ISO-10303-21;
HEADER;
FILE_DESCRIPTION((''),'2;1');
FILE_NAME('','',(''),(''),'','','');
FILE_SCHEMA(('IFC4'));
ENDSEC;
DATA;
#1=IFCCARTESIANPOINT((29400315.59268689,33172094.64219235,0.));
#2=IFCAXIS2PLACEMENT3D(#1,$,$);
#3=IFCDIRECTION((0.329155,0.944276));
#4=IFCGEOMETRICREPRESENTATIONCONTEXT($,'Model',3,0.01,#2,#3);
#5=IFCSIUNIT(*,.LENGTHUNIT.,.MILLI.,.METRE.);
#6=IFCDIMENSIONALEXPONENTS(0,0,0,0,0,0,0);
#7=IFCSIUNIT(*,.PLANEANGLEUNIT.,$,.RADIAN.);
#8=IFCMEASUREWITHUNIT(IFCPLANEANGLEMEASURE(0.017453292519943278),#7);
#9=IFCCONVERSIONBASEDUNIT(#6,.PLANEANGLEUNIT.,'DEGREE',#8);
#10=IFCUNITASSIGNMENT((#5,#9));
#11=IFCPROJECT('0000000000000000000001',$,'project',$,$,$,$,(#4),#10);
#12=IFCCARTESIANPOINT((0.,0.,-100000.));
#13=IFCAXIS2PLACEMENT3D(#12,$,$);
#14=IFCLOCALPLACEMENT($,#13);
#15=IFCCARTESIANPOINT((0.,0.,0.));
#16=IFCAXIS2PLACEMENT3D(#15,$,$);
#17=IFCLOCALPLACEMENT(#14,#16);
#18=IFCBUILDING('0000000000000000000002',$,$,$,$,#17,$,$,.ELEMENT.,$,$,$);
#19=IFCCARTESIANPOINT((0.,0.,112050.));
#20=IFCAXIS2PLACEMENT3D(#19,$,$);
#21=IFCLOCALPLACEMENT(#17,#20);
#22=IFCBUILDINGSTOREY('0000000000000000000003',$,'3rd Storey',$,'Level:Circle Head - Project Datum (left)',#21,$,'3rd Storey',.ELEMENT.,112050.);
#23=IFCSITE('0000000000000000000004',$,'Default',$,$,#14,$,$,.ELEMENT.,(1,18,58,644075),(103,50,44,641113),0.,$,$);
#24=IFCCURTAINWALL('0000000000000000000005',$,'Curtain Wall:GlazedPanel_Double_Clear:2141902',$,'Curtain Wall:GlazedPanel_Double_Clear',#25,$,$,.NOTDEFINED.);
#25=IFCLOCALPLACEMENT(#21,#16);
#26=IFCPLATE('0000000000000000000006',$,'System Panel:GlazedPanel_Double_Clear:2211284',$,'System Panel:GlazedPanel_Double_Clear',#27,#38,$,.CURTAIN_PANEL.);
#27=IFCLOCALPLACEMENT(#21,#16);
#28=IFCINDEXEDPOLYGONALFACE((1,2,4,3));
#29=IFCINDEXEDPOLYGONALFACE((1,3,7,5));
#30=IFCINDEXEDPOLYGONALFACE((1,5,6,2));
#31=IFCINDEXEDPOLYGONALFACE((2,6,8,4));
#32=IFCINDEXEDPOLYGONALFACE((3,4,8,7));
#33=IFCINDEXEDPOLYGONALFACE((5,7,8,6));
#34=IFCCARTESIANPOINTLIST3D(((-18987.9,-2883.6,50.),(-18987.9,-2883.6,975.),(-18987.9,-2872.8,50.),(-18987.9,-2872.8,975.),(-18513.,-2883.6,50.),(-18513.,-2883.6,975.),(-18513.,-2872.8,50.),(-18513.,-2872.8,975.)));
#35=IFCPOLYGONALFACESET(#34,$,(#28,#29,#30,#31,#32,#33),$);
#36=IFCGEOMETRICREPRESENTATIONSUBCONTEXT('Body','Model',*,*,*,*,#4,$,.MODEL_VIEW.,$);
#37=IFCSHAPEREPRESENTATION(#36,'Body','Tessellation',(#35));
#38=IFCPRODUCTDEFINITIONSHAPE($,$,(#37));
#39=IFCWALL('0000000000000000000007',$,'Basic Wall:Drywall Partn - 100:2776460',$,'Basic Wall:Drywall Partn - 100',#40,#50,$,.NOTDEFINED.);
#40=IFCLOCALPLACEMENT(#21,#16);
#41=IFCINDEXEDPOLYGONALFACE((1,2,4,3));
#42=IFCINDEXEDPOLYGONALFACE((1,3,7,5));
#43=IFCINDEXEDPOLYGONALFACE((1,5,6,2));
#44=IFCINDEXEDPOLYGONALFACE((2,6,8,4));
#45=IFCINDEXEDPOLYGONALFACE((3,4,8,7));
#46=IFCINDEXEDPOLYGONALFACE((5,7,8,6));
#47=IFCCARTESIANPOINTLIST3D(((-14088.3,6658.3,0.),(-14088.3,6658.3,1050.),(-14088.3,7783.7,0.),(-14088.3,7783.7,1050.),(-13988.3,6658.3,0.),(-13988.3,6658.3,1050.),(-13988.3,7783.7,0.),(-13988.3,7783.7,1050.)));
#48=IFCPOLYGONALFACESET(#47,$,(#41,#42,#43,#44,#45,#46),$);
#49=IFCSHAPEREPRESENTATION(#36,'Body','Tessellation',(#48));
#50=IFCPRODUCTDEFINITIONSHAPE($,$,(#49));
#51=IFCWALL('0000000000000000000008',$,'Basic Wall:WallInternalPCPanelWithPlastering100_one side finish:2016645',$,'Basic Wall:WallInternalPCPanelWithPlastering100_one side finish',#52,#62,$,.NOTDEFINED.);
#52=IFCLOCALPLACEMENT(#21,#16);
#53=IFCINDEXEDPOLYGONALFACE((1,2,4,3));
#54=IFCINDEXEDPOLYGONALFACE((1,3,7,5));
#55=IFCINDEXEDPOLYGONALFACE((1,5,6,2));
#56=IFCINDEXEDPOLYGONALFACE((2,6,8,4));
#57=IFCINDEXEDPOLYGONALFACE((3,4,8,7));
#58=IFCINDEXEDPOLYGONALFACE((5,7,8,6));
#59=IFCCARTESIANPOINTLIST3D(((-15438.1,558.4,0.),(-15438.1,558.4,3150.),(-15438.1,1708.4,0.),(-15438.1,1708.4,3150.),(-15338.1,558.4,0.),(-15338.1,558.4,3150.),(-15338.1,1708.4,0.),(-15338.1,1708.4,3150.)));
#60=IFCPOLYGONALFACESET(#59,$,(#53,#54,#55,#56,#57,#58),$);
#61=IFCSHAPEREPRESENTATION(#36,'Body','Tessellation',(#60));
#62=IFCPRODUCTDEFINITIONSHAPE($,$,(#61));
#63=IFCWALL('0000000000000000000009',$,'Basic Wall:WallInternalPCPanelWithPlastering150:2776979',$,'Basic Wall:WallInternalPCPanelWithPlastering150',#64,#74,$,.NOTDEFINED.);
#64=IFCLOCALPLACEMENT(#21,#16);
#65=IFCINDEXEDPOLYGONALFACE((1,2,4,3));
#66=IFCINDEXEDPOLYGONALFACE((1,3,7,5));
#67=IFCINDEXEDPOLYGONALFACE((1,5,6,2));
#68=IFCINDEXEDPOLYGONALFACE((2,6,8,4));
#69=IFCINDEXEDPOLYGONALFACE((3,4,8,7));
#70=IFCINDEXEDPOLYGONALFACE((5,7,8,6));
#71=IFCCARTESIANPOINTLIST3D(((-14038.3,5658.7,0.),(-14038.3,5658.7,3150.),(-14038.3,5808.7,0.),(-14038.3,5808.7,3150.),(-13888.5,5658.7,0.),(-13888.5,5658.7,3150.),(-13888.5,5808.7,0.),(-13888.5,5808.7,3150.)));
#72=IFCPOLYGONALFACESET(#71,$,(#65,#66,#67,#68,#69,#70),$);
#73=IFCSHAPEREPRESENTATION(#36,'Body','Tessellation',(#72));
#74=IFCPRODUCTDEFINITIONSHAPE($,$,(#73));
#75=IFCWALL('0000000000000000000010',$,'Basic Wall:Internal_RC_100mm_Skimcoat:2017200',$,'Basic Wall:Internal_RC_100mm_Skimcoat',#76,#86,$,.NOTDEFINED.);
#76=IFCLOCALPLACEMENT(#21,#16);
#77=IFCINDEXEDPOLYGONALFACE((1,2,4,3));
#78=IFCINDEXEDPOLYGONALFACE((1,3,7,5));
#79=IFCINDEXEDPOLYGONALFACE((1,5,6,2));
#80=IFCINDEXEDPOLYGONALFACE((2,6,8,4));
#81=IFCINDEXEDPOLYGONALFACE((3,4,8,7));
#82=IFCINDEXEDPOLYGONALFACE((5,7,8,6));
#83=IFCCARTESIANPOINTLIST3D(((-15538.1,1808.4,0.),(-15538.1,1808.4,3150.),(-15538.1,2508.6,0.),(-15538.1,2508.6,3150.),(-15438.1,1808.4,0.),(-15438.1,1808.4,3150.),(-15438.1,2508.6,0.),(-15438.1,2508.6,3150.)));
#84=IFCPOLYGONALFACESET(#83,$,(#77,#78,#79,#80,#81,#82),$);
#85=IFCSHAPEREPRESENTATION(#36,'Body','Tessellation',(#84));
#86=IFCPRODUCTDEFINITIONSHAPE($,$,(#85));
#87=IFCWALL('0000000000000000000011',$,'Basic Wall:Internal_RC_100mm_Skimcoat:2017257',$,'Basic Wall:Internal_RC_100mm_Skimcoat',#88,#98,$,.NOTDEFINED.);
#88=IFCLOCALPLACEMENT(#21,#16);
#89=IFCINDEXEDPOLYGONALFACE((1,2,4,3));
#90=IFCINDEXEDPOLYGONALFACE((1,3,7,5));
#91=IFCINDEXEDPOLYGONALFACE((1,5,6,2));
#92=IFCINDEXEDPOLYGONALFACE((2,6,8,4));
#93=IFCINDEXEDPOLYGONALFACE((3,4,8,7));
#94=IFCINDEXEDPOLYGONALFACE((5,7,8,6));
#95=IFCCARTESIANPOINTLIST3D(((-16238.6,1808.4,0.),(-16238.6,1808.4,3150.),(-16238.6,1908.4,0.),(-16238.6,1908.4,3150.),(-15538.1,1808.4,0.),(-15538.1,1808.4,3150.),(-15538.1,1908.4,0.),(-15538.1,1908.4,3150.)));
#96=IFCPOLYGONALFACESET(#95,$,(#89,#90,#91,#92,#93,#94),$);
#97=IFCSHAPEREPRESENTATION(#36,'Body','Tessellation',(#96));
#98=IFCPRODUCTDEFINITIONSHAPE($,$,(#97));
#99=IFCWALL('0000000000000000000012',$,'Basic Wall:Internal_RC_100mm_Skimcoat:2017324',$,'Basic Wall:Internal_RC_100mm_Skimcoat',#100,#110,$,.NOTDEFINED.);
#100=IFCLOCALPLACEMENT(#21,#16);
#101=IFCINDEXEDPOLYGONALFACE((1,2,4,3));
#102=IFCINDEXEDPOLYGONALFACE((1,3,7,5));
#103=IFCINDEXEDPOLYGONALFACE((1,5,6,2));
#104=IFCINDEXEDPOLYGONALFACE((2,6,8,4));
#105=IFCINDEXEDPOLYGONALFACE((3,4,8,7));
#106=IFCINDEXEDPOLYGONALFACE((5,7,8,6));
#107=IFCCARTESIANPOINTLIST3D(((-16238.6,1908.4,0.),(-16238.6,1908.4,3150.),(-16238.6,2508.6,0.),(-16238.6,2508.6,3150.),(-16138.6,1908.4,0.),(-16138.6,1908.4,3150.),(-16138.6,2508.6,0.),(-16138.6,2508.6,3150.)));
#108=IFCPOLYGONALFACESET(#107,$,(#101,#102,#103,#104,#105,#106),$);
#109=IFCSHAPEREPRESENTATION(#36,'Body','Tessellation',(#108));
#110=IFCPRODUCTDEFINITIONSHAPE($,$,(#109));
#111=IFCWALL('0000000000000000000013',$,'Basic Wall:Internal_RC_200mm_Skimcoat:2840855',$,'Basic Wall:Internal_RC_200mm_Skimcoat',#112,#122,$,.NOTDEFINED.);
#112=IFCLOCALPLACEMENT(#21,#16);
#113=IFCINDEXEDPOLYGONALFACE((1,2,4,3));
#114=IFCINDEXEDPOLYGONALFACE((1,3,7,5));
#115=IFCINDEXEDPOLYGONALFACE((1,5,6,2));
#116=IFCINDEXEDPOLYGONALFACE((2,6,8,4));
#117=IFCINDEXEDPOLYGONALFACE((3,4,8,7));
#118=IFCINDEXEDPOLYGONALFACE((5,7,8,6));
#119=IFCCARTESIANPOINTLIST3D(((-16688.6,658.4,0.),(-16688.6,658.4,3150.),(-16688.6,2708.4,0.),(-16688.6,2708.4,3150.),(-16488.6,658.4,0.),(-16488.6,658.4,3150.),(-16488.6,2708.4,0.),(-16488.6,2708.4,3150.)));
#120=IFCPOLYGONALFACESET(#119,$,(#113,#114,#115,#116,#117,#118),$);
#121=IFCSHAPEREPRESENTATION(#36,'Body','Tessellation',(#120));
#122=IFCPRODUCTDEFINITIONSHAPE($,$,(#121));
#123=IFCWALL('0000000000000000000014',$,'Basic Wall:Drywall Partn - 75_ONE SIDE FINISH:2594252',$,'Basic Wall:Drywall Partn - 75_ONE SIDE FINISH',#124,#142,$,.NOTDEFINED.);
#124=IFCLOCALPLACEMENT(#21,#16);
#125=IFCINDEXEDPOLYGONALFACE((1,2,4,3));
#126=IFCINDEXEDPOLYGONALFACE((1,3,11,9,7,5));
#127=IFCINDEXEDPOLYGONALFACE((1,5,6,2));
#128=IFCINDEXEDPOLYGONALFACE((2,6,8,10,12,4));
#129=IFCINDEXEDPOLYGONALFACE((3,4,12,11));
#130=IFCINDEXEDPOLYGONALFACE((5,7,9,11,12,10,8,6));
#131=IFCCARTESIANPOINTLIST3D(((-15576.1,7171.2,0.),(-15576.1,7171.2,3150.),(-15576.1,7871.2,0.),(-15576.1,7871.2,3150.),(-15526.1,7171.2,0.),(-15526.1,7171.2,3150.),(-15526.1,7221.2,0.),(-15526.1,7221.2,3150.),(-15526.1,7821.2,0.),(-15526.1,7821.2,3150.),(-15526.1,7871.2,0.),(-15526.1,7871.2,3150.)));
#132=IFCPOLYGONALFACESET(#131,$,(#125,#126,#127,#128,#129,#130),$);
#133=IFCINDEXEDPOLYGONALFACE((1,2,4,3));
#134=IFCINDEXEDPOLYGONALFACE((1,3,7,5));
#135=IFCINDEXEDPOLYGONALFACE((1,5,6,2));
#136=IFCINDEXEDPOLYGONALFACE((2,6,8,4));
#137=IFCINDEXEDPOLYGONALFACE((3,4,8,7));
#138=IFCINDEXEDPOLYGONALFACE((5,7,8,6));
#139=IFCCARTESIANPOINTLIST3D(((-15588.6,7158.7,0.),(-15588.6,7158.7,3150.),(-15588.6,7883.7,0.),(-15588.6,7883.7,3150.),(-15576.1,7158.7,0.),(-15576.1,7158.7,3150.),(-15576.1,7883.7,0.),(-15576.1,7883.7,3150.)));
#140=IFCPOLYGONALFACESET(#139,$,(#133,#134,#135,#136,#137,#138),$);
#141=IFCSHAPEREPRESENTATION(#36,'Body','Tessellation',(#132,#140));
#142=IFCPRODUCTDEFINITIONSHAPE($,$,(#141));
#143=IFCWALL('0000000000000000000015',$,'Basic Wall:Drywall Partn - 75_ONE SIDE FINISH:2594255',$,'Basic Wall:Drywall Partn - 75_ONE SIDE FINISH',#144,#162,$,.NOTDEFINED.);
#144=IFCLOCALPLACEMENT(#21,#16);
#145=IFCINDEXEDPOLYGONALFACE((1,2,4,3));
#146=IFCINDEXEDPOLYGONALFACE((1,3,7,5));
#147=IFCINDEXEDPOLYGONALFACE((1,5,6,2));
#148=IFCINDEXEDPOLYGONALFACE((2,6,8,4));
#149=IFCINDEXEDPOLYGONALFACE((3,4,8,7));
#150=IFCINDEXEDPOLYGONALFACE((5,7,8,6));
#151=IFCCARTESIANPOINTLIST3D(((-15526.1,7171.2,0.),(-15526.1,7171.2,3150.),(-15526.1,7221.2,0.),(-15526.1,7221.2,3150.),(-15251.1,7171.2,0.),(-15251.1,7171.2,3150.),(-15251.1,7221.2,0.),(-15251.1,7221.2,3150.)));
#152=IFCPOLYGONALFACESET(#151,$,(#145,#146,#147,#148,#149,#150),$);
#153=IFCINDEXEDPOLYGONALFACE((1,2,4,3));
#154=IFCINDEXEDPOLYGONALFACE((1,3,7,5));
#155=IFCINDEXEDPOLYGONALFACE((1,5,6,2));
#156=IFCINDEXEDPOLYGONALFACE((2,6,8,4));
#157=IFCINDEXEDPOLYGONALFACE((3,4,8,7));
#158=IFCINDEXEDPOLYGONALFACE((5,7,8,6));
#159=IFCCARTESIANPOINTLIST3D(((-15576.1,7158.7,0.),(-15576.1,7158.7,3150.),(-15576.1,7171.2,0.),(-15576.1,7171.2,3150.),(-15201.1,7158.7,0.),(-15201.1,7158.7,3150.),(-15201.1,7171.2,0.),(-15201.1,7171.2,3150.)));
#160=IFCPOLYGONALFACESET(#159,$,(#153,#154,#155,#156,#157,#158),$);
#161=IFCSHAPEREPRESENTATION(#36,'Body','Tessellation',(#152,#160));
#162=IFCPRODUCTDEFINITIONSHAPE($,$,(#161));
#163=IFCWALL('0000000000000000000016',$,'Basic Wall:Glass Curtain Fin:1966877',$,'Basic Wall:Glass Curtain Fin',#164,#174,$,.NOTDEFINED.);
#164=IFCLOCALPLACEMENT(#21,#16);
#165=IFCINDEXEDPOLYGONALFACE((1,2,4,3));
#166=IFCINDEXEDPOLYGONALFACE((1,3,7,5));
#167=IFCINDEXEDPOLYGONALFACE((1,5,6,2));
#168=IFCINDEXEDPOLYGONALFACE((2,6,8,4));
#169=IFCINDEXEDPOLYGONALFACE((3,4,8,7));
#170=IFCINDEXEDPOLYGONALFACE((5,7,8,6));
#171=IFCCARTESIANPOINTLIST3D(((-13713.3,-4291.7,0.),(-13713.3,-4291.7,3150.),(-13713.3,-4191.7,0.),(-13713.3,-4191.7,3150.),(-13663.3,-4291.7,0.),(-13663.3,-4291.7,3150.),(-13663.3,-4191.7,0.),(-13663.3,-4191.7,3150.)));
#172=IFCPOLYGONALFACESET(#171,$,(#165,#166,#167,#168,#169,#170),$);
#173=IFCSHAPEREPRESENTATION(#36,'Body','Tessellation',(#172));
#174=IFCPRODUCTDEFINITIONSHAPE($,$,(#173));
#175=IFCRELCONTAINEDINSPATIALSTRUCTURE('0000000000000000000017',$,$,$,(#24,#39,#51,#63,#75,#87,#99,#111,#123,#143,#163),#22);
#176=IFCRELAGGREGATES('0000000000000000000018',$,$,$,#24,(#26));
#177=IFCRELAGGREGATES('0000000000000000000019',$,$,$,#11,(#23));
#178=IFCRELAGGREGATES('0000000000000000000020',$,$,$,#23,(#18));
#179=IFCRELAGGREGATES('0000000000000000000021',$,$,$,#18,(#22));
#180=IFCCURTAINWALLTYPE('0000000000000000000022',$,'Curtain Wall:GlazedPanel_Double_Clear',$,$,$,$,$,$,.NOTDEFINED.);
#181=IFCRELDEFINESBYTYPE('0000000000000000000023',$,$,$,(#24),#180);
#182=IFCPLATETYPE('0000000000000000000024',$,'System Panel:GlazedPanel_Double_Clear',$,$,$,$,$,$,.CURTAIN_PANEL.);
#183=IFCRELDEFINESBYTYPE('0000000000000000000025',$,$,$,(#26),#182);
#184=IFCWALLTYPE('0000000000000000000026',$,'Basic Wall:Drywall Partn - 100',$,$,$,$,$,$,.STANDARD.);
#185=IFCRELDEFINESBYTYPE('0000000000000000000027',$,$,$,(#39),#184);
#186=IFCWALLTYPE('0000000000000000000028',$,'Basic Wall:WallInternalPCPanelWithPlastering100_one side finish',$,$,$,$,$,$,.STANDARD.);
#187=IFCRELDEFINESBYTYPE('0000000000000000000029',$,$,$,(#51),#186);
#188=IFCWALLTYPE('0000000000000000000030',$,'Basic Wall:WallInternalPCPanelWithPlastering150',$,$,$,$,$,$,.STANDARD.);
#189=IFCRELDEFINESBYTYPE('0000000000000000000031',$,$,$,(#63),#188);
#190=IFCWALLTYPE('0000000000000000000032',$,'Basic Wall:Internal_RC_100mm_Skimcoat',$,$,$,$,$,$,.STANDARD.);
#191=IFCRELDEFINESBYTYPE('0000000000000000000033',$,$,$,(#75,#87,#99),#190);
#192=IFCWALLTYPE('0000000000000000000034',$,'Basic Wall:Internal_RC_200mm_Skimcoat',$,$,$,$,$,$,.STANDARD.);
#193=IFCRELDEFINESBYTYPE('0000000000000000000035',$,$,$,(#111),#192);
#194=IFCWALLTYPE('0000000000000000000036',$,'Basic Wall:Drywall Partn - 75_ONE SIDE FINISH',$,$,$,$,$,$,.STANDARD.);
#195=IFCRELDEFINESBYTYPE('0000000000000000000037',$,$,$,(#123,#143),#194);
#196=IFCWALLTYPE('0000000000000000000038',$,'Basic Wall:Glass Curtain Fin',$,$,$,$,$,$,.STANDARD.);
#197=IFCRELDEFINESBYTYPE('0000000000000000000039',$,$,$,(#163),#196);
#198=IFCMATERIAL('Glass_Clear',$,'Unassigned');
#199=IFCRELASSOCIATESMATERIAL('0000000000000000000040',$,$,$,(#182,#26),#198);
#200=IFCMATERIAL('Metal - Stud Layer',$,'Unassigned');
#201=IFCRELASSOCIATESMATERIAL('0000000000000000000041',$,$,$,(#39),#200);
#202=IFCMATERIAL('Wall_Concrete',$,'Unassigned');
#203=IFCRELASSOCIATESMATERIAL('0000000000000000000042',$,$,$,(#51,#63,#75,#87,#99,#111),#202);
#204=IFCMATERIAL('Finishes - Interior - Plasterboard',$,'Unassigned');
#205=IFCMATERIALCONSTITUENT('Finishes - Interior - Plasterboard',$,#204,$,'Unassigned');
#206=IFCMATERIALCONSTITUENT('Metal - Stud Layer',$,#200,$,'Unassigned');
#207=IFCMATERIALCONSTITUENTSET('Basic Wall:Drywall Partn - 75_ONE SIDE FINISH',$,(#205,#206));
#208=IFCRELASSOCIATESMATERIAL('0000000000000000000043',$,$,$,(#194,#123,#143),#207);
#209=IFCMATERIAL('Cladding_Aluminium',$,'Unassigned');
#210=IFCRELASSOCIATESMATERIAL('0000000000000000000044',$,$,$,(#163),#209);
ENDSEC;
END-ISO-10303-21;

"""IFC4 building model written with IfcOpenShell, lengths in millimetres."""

from ifc_helpers import new_model, entity, si_unit, converted_unit, direction, frame, origin, place, context, subcontext, project, spatial, indexed_curve, outline, extrude, source, transform, mapped, material, constituent, constituent_set, type_object, type_shapes, element, aggregate, save


model = new_model("IFC4")

# Units and contexts
model_context = context("Model", 3, precision=0.01, world=frame((29400315.59268689, 33172094.64219235, 0.0)), true_north=direction((0.329155, 0.944276)))
body_context = subcontext(model_context, "Body", "Model", "MODEL_VIEW")
ifc_project = project(units=[si_unit("LENGTHUNIT", "METRE", prefix="MILLI"), converted_unit("PLANEANGLEUNIT", "DEGREE", entity("IfcPlaneAngleMeasure", 0.017453292519943278), si_unit("PLANEANGLEUNIT", "RADIAN"), dimensions=[0, 0, 0, 0, 0, 0, 0])], contexts=[model_context])

# Site, building, storey
site_placement = place(None, frame((0.0, 0.0, -100000.0)))
site = spatial("IfcSite", under=ifc_project, at=site_placement, Name="Default", CompositionType="ELEMENT", RefLatitude=(1, 18, 58, 644075), RefLongitude=(103, 50, 44, 641113), RefElevation=0.0)
building_placement = place(site_placement, origin())
building = spatial("IfcBuilding", under=site, at=building_placement, CompositionType="ELEMENT")
storey_placement = place(building_placement, frame((0.0, 0.0, 112050.0)))
storey = spatial("IfcBuildingStorey", under=building, at=storey_placement, Name="3rd Storey", ObjectType="Level:Circle Head - Project Datum (left)", LongName="3rd Storey", CompositionType="ELEMENT", Elevation=112050.0)

# Shared definitions
curtain_wall_type = type_object("IfcCurtainWallType", Name="Curtain Wall:GlazedPanel_Double_Clear", PredefinedType="NOTDEFINED")

# Curtain wall
curtain_wall_1_placement = place(storey_placement, frame((0.0, 0.0, -112050.0)))
curtain_wall_1 = element("IfcCurtainWall", 1, at=curtain_wall_1_placement, inside=storey, type_object=curtain_wall_type, Name="Curtain Wall:GlazedPanel_Double_Clear:2141902", ObjectType="Curtain Wall:GlazedPanel_Double_Clear", PredefinedType="NOTDEFINED")

# Plate
ifc_material_1 = material(Name="Glass_Clear", Category="Unassigned")
plate_type_1 = type_object("IfcPlateType", Name="System Panel:GlazedPanel_Double_Clear", PredefinedType="CURTAIN_PANEL", material=ifc_material_1)
shared_shape_1 = source(origin(), body_context, "Body", "SweptSolid", [
    extrude(outline(indexed_curve([(-5.4, -237.5), (5.4, -237.5), (5.4, 237.5), (-5.4, 237.5), (-5.4, -237.5)], self_intersect=False)), frame((0.0, -111.0, 0.0), z_axis=(0.0, 0.0, 1.0), x_axis=(0.0, 1.0, 0.0)), (0.0, 0.0, 1.0), 925.0),
])
type_shapes(plate_type_1, [shared_shape_1])
plate_1_placement = place(curtain_wall_1_placement, frame((-18750.4, -2767.2, 112100.0)))
plate_1 = element("IfcPlate", 2, at=plate_1_placement, type_object=plate_type_1, material=ifc_material_1, Name="System Panel:GlazedPanel_Double_Clear:2211284", ObjectType="System Panel:GlazedPanel_Double_Clear", PredefinedType="CURTAIN_PANEL", context=body_context, shape_type="MappedRepresentation", body=[
    mapped(shared_shape_1, transform((0.0, 0.0, 0.0), scale=1.0)),
])
aggregate(curtain_wall_1, [plate_1])

# Walls
ifc_material_2 = material(Name="Metal - Stud Layer", Category="Unassigned")
wall_type_1 = type_object("IfcWallType", Name="Basic Wall:Drywall Partn - 100", PredefinedType="STANDARD")
wall_1_placement = place(storey_placement, frame((-14038.3, 7783.7, 0.0), z_axis=(0.0, 0.0, 1.0), x_axis=(0.0, -1.0, 0.0)))
element("IfcWall", 3, at=wall_1_placement, inside=storey, type_object=wall_type_1, material=ifc_material_2, Name="Basic Wall:Drywall Partn - 100:2776460", ObjectType="Basic Wall:Drywall Partn - 100", PredefinedType="NOTDEFINED", context=body_context, shape_type="SweptSolid", body=[
    extrude(outline(indexed_curve([(1125.4, 50.0), (0.0, 50.0), (0.0, -50.0), (1125.4, -50.0), (1125.4, 50.0)], self_intersect=False)), origin(), (0.0, 0.0, 1.0), 1050.0),
])
ifc_material_3 = material(Name="Wall_Concrete", Category="Unassigned")
wall_type_2 = type_object("IfcWallType", Name="Basic Wall:WallInternalPCPanelWithPlastering100_one side finish", PredefinedType="STANDARD")
wall_2_placement = place(storey_placement, frame((-15388.1, 558.4, 0.0), z_axis=(0.0, 0.0, 1.0), x_axis=(0.0, 1.0, 0.0)))
element("IfcWall", 4, at=wall_2_placement, inside=storey, type_object=wall_type_2, material=ifc_material_3, Name="Basic Wall:WallInternalPCPanelWithPlastering100_one side finish:2016645", ObjectType="Basic Wall:WallInternalPCPanelWithPlastering100_one side finish", PredefinedType="NOTDEFINED", context=body_context, shape_type="SweptSolid", body=[
    extrude(outline(indexed_curve([(1150.0, 50.0), (0.0, 50.0), (0.0, -50.0), (1150.0, -50.0), (1150.0, 50.0)], self_intersect=False)), origin(), (0.0, 0.0, 1.0), 3150.0),
])
wall_type_3 = type_object("IfcWallType", Name="Basic Wall:WallInternalPCPanelWithPlastering150", PredefinedType="STANDARD")
wall_3_placement = place(storey_placement, frame((-13888.5, 5733.7, 0.0), z_axis=(0.0, 0.0, 1.0), x_axis=(-1.0, 0.0, 0.0)))
element("IfcWall", 5, at=wall_3_placement, inside=storey, type_object=wall_type_3, material=ifc_material_3, Name="Basic Wall:WallInternalPCPanelWithPlastering150:2776979", ObjectType="Basic Wall:WallInternalPCPanelWithPlastering150", PredefinedType="NOTDEFINED", context=body_context, shape_type="SweptSolid", body=[
    extrude(outline(indexed_curve([(149.9, 75.0), (0.0, 75.0), (0.0, -75.0), (149.9, -75.0), (149.9, 75.0)], self_intersect=False)), origin(), (0.0, 0.0, 1.0), 3150.0),
])
wall_type_4 = type_object("IfcWallType", Name="Basic Wall:Internal_RC_100mm_Skimcoat", PredefinedType="STANDARD")
wall_4_placement = place(storey_placement, frame((-15488.1, 2508.6, 0.0), z_axis=(0.0, 0.0, 1.0), x_axis=(0.0, -1.0, 0.0)))
element("IfcWall", 6, at=wall_4_placement, inside=storey, type_object=wall_type_4, material=ifc_material_3, Name="Basic Wall:Internal_RC_100mm_Skimcoat:2017200", ObjectType="Basic Wall:Internal_RC_100mm_Skimcoat", PredefinedType="NOTDEFINED", context=body_context, shape_type="SweptSolid", body=[
    extrude(outline(indexed_curve([(700.1, 50.0), (0.0, 50.0), (0.0, -50.0), (700.1, -50.0), (700.1, 50.0)], self_intersect=False)), origin(), (0.0, 0.0, 1.0), 3150.0),
])
wall_5_placement = place(storey_placement, frame((-15538.1, 1858.4, 0.0), z_axis=(0.0, 0.0, 1.0), x_axis=(-1.0, 0.0, 0.0)))
element("IfcWall", 7, at=wall_5_placement, inside=storey, type_object=wall_type_4, material=ifc_material_3, Name="Basic Wall:Internal_RC_100mm_Skimcoat:2017257", ObjectType="Basic Wall:Internal_RC_100mm_Skimcoat", PredefinedType="NOTDEFINED", context=body_context, shape_type="SweptSolid", body=[
    extrude(outline(indexed_curve([(700.5, 50.0), (0.0, 50.0), (0.0, -50.0), (700.5, -50.0), (700.5, 50.0)], self_intersect=False)), origin(), (0.0, 0.0, 1.0), 3150.0),
])
wall_6_placement = place(storey_placement, frame((-16188.6, 2508.6, 0.0), z_axis=(0.0, 0.0, 1.0), x_axis=(0.0, -1.0, 0.0)))
element("IfcWall", 8, at=wall_6_placement, inside=storey, type_object=wall_type_4, material=ifc_material_3, Name="Basic Wall:Internal_RC_100mm_Skimcoat:2017324", ObjectType="Basic Wall:Internal_RC_100mm_Skimcoat", PredefinedType="NOTDEFINED", context=body_context, shape_type="SweptSolid", body=[
    extrude(outline(indexed_curve([(600.1, 50.0), (0.0, 50.0), (0.0, -50.0), (600.1, -50.0), (600.1, 50.0)], self_intersect=False)), origin(), (0.0, 0.0, 1.0), 3150.0),
])
wall_type_5 = type_object("IfcWallType", Name="Basic Wall:Internal_RC_200mm_Skimcoat", PredefinedType="STANDARD")
wall_7_placement = place(storey_placement, frame((-16588.6, 658.4, 0.0), z_axis=(0.0, 0.0, 1.0), x_axis=(0.0, 1.0, 0.0)))
element("IfcWall", 9, at=wall_7_placement, inside=storey, type_object=wall_type_5, material=ifc_material_3, Name="Basic Wall:Internal_RC_200mm_Skimcoat:2840855", ObjectType="Basic Wall:Internal_RC_200mm_Skimcoat", PredefinedType="NOTDEFINED", context=body_context, shape_type="SweptSolid", body=[
    extrude(outline(indexed_curve([(2050.0, 100.0), (0.0, 100.0), (0.0, -100.0), (2050.0, -100.0), (2050.0, 100.0)], self_intersect=False)), origin(), (0.0, 0.0, 1.0), 3150.0),
])
ifc_material_4 = material(Name="Finishes - Interior - Plasterboard", Category="Unassigned")
ifc_constituent_1 = constituent(ifc_material_4, Name="Finishes - Interior - Plasterboard", Category="Unassigned")
ifc_constituent_2 = constituent(ifc_material_2, Name="Metal - Stud Layer", Category="Unassigned")
ifc_constituent_set = constituent_set(constituents=[ifc_constituent_1, ifc_constituent_2], Name="Basic Wall:Drywall Partn - 75_ONE SIDE FINISH")
wall_type_6 = type_object("IfcWallType", Name="Basic Wall:Drywall Partn - 75_ONE SIDE FINISH", PredefinedType="STANDARD", material=ifc_constituent_set)
wall_8_placement = place(storey_placement, frame((-15557.3, 7158.7, 0.0), z_axis=(0.0, 0.0, 1.0), x_axis=(0.0, 1.0, 0.0)))
element("IfcWall", 10, at=wall_8_placement, inside=storey, type_object=wall_type_6, material=ifc_constituent_set, Name="Basic Wall:Drywall Partn - 75_ONE SIDE FINISH:2594252", ObjectType="Basic Wall:Drywall Partn - 75_ONE SIDE FINISH", PredefinedType="NOTDEFINED", context=body_context, shape_type="SweptSolid", body=[
    extrude(outline(indexed_curve([(-300.0, -16.7), (300.0, -16.7), (350.0, -16.7), (350.0, 33.3), (-350.0, 33.3), (-350.0, -16.7), (-300.0, -16.7)], self_intersect=False)), frame((362.5, -14.6, 0.0)), (0.0, 0.0, 1.0), 3150.0),
    extrude(outline(indexed_curve([(-6.3, -362.5), (6.2, -362.5), (6.2, 362.5), (-6.3, 362.5), (-6.3, -362.5)], self_intersect=False)), frame((362.5, 25.0, 0.0), z_axis=(0.0, 0.0, 1.0), x_axis=(0.0, -1.0, 0.0)), (0.0, 0.0, 1.0), 3150.0),
])
wall_9_placement = place(storey_placement, frame((-15526.1, 7189.9, 0.0)))
element("IfcWall", 11, at=wall_9_placement, inside=storey, type_object=wall_type_6, material=ifc_constituent_set, Name="Basic Wall:Drywall Partn - 75_ONE SIDE FINISH:2594255", ObjectType="Basic Wall:Drywall Partn - 75_ONE SIDE FINISH", PredefinedType="NOTDEFINED", context=body_context, shape_type="SweptSolid", body=[
    extrude(outline(indexed_curve([(-25.0, -137.5), (25.0, -137.5), (25.0, 137.5), (-25.0, 137.5), (-25.0, -137.5)], self_intersect=False)), frame((137.5, 6.3, 0.0), z_axis=(0.0, 0.0, 1.0), x_axis=(0.0, -1.0, 0.0)), (0.0, 0.0, 1.0), 3150.0),
    extrude(outline(indexed_curve([(-6.3, -187.5), (6.2, -187.5), (6.3, 187.5), (-6.2, 187.5), (-6.3, -187.5)], self_intersect=False)), frame((137.5, -25.0, 0.0), z_axis=(0.0, 0.0, 1.0), x_axis=(0.0, 1.0, 0.0)), (0.0, 0.0, 1.0), 3150.0),
])
ifc_material_5 = material(Name="Cladding_Aluminium", Category="Unassigned")
wall_type_7 = type_object("IfcWallType", Name="Basic Wall:Glass Curtain Fin", PredefinedType="STANDARD")
wall_10_placement = place(storey_placement, frame((-13688.3, -4191.7, 0.0), z_axis=(0.0, 0.0, 1.0), x_axis=(0.0, -1.0, 0.0)))
element("IfcWall", 12, at=wall_10_placement, inside=storey, type_object=wall_type_7, material=ifc_material_5, Name="Basic Wall:Glass Curtain Fin:1966877", ObjectType="Basic Wall:Glass Curtain Fin", PredefinedType="NOTDEFINED", context=body_context, shape_type="SweptSolid", body=[
    extrude(outline(indexed_curve([(100.0, 25.0), (0.0, 25.0), (0.0, -25.0), (100.0, -25.0), (100.0, 25.0)], self_intersect=False)), origin(), (0.0, 0.0, 1.0), 3150.0),
])

save(model, "model.ifc")
